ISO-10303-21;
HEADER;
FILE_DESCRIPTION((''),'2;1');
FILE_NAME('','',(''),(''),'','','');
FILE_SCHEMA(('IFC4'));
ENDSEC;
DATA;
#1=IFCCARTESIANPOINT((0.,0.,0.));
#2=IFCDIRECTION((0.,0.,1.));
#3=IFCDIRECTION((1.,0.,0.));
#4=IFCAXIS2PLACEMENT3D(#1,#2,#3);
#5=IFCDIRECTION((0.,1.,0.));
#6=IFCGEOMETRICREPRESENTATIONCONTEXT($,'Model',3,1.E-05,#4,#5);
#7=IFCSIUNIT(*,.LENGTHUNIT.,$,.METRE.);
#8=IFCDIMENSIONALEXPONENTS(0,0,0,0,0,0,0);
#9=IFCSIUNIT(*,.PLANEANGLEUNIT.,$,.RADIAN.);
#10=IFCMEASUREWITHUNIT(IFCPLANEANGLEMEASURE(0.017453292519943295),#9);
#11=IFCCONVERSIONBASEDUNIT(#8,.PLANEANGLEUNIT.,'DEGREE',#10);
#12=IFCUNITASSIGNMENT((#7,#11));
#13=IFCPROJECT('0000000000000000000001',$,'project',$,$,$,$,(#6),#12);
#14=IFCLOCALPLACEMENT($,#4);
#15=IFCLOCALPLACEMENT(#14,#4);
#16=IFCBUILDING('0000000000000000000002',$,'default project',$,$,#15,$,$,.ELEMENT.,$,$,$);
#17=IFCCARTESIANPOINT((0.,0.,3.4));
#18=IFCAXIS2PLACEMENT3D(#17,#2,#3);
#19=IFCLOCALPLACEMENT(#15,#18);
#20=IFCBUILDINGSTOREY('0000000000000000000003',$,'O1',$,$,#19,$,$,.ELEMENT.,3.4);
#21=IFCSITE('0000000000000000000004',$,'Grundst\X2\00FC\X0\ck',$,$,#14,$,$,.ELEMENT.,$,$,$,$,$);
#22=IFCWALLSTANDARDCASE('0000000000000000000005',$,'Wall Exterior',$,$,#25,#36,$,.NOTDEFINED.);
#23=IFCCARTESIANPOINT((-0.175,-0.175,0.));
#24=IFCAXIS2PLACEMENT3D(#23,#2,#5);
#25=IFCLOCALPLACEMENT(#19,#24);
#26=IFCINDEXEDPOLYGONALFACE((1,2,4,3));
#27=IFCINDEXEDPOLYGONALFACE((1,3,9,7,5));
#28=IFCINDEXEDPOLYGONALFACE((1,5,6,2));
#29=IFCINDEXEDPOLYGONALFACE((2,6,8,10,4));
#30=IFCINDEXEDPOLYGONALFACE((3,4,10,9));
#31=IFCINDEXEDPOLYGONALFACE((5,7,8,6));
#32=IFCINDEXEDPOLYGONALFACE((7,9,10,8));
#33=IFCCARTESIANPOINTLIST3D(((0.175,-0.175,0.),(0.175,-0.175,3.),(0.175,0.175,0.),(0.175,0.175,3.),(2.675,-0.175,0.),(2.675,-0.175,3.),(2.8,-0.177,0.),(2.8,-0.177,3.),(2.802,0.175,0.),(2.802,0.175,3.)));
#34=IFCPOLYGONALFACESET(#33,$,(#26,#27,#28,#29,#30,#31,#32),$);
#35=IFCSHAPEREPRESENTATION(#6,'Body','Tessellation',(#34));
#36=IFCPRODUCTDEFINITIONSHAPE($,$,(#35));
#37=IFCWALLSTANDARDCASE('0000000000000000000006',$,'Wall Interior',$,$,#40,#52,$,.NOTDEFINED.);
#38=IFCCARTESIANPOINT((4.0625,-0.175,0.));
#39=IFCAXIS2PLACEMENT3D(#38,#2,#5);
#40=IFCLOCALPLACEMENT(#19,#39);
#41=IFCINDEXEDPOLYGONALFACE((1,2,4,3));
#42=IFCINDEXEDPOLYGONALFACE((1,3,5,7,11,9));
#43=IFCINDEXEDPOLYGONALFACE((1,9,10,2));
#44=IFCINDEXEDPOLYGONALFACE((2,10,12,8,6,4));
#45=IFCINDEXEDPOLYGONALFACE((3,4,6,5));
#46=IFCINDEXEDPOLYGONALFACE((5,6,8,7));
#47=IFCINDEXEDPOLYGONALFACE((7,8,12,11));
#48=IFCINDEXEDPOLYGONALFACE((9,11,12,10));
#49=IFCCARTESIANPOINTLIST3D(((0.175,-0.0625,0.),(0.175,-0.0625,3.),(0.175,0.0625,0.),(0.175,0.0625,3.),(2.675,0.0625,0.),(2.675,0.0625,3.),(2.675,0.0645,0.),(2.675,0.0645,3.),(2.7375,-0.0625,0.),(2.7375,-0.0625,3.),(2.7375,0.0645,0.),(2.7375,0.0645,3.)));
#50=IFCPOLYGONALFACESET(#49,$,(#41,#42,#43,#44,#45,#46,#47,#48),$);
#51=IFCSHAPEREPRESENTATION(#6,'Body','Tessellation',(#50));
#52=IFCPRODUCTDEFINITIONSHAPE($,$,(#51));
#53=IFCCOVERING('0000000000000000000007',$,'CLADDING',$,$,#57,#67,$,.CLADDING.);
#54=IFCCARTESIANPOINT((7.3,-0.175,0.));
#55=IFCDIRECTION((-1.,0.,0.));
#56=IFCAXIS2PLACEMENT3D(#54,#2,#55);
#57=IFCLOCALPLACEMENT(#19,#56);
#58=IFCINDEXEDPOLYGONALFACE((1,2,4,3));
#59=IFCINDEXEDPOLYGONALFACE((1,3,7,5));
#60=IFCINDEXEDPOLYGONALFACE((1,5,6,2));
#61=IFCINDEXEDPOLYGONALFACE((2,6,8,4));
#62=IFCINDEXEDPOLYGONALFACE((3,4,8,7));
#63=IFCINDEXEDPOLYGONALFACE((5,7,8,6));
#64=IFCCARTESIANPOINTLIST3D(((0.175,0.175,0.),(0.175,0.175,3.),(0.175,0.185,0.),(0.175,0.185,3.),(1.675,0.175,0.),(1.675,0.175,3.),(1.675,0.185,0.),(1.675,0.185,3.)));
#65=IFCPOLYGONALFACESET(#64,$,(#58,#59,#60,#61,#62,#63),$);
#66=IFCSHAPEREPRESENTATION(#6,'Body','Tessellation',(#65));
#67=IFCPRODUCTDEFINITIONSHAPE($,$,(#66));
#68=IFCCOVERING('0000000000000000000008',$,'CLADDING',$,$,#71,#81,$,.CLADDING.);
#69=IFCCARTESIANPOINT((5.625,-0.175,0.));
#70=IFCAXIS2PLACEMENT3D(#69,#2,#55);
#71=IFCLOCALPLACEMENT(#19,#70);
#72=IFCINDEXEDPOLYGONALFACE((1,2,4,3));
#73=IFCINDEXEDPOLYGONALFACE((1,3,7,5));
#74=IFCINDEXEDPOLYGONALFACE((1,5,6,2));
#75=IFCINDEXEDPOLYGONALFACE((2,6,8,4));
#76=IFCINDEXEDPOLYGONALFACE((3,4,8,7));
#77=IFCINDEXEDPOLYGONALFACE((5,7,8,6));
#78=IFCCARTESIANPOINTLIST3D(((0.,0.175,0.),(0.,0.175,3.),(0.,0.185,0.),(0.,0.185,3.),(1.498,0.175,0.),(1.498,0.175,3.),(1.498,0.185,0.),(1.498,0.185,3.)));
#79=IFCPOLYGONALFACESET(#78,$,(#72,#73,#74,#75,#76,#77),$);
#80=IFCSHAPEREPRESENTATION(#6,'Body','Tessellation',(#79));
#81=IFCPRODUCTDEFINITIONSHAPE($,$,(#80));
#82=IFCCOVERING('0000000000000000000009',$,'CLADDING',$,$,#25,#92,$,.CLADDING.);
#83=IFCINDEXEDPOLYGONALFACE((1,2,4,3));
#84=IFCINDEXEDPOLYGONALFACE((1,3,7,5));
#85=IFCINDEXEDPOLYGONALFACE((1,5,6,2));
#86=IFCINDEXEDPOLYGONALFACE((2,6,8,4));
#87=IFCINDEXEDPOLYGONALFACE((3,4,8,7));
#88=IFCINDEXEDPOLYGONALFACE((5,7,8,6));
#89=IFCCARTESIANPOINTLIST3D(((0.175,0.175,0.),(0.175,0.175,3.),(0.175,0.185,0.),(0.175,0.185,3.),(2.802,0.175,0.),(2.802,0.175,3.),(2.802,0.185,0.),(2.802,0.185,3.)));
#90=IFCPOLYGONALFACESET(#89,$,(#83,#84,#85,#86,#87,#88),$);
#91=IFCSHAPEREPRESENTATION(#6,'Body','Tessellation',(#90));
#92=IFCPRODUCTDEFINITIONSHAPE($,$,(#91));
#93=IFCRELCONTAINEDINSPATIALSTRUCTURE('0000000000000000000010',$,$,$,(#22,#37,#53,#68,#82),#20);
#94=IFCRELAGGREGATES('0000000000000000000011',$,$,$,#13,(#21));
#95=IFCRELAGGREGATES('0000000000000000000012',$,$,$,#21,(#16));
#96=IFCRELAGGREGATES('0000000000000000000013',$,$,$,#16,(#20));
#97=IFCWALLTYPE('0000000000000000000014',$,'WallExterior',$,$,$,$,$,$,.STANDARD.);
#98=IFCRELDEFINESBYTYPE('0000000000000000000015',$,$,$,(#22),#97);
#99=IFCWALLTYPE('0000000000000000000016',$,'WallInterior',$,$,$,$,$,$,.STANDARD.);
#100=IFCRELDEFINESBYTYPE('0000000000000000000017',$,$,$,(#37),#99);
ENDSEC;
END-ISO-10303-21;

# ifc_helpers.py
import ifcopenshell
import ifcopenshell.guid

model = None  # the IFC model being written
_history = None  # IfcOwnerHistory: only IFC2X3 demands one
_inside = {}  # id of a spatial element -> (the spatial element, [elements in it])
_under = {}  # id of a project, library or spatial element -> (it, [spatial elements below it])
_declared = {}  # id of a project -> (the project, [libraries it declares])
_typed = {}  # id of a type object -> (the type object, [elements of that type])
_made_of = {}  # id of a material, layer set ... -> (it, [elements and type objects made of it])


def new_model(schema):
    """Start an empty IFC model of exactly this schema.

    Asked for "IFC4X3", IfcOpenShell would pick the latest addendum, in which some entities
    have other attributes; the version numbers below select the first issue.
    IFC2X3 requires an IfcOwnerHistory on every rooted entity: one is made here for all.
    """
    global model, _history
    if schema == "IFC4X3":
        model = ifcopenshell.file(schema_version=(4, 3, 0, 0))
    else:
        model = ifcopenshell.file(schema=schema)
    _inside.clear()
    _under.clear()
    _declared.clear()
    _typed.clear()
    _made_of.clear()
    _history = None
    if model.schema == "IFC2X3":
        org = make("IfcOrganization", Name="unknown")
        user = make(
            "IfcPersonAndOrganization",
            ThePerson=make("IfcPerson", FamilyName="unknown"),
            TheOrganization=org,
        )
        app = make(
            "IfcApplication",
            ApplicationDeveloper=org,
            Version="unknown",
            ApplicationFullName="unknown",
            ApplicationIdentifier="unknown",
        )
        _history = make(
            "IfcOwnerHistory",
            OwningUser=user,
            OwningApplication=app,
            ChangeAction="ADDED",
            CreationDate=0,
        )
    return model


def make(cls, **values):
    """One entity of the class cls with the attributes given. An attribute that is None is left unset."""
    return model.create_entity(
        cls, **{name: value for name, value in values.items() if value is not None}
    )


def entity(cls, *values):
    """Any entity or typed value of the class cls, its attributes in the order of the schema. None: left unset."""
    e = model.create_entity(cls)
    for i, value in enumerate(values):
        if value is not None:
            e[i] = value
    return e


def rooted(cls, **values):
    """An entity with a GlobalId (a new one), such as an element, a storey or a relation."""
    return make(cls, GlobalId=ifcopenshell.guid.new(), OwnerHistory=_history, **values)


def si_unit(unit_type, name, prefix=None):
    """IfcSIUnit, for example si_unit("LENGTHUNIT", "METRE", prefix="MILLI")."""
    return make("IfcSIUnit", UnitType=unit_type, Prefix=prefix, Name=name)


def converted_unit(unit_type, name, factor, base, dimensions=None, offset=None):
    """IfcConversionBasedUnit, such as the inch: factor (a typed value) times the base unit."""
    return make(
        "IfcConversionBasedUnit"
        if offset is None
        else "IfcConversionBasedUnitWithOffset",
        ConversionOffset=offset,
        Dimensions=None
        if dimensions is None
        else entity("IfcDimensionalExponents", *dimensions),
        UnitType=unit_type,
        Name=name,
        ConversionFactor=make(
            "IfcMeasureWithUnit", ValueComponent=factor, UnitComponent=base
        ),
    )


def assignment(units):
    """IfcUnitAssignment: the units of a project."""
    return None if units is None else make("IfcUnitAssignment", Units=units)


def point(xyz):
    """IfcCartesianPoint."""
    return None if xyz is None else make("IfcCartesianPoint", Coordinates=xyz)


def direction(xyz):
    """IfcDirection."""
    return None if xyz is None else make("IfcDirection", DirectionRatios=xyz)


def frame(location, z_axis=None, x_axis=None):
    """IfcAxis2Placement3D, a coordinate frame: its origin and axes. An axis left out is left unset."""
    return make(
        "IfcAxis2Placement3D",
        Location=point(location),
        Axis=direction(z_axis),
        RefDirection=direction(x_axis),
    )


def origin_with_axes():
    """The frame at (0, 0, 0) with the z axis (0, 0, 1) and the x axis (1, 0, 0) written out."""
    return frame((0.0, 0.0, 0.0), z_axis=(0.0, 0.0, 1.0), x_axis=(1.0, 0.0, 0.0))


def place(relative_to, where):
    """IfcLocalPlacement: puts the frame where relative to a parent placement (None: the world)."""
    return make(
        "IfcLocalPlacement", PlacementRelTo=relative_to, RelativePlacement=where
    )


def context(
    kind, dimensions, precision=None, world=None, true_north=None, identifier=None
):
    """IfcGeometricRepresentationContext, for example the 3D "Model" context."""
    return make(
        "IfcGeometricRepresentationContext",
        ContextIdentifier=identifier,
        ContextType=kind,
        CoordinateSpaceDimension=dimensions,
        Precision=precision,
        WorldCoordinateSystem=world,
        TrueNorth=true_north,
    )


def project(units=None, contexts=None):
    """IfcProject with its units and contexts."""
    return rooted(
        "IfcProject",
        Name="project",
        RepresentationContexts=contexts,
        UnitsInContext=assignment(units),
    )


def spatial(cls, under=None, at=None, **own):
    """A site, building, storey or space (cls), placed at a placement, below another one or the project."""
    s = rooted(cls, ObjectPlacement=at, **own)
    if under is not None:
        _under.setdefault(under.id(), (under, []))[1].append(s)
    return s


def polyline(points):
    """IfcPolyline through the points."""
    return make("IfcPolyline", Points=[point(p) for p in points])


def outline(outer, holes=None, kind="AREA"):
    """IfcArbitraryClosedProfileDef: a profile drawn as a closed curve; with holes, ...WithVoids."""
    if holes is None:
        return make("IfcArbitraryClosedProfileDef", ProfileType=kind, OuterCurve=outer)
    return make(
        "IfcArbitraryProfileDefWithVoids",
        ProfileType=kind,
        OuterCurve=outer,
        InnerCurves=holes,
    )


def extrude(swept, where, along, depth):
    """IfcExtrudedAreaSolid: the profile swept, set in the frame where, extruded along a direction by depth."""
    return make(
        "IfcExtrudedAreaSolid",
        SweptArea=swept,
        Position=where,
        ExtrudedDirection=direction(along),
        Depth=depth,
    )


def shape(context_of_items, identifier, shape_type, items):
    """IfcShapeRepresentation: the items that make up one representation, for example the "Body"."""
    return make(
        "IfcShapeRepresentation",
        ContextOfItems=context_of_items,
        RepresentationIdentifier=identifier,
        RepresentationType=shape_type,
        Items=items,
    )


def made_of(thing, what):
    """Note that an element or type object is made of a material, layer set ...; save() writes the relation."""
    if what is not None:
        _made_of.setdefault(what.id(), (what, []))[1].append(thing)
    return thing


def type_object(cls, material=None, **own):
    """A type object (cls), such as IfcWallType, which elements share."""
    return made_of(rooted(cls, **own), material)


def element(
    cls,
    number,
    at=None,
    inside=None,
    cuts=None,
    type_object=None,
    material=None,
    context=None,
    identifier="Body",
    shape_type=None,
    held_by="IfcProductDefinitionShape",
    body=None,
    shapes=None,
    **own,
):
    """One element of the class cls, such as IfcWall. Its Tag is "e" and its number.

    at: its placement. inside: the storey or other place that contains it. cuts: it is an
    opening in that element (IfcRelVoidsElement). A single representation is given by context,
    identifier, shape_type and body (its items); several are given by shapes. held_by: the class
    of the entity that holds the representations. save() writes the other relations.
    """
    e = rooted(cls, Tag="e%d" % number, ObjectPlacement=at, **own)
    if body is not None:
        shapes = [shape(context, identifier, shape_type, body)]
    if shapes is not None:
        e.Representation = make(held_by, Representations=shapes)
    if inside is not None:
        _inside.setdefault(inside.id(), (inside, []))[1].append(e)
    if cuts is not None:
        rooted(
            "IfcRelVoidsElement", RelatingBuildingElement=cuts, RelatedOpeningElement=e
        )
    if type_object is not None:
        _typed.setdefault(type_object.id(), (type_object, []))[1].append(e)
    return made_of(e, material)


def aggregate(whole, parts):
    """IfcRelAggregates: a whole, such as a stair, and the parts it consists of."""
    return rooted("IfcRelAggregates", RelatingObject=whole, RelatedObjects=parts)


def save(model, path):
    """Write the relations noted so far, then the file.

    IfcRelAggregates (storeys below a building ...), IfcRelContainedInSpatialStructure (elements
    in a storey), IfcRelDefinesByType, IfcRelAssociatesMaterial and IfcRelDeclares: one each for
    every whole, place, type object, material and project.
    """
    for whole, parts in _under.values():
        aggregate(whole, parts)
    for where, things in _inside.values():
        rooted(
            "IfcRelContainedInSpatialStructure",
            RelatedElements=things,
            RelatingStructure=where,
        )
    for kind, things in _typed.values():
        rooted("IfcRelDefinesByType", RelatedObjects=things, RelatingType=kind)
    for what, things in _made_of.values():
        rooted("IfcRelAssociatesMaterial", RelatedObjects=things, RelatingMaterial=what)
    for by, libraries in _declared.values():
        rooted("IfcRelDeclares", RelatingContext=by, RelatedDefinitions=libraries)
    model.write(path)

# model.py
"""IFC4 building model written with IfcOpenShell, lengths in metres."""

from ifc_helpers import new_model, entity, si_unit, converted_unit, direction, frame, origin_with_axes, place, context, project, spatial, polyline, outline, extrude, type_object, element, save


model = new_model("IFC4")

# Units and contexts
model_context = context("Model", 3, precision=1e-05, world=origin_with_axes(), true_north=direction((0.0, 1.0, 0.0)))
ifc_project = project(units=[si_unit("LENGTHUNIT", "METRE"), converted_unit("PLANEANGLEUNIT", "DEGREE", entity("IfcPlaneAngleMeasure", 0.017453292519943295), si_unit("PLANEANGLEUNIT", "RADIAN"), dimensions=[0, 0, 0, 0, 0, 0, 0])], contexts=[model_context])

# Site, building, storey
site_placement = place(None, origin_with_axes())
site = spatial("IfcSite", under=ifc_project, at=site_placement, Name="Grundstück", CompositionType="ELEMENT")
building_placement = place(site_placement, origin_with_axes())
building = spatial("IfcBuilding", under=site, at=building_placement, Name="default project", CompositionType="ELEMENT")
placement_1 = place(building_placement, frame((0.0, 0.0, 3.4), z_axis=(0.0, 0.0, 1.0), x_axis=(1.0, 0.0, 0.0)))
storey = spatial("IfcBuildingStorey", under=building, at=placement_1, Name="O1", CompositionType="ELEMENT", Elevation=3.4)

# Walls
wall_type_1 = type_object("IfcWallType", Name="WallExterior", PredefinedType="STANDARD")
placement_2 = place(placement_1, frame((7.3, -0.175, 0.0), z_axis=(0.0, 0.0, 1.0), x_axis=(-1.0, 0.0, 0.0)))
placement_3 = place(placement_1, frame((5.625, -0.175, 0.0), z_axis=(0.0, 0.0, 1.0), x_axis=(-1.0, 0.0, 0.0)))
placement_4 = place(placement_1, frame((-0.175, -0.175, 0.0), z_axis=(0.0, 0.0, 1.0), x_axis=(0.0, 1.0, 0.0)))
element("IfcWallStandardCase", 1, at=placement_4, inside=storey, type_object=wall_type_1, Name="Wall Exterior", PredefinedType="NOTDEFINED", context=model_context, shape_type="SweptSolid", body=[
    extrude(outline(polyline([(2.802, 0.175), (0.175, 0.175), (0.175, -0.175), (2.675, -0.175), (2.8, -0.177), (2.802, 0.175)])), origin_with_axes(), (0.0, 0.0, 1.0), 3.0),
])
wall_type_2 = type_object("IfcWallType", Name="WallInterior", PredefinedType="STANDARD")
wall_1_placement = place(placement_1, frame((4.0625, -0.175, 0.0), z_axis=(0.0, 0.0, 1.0), x_axis=(0.0, 1.0, 0.0)))
element("IfcWallStandardCase", 2, at=wall_1_placement, inside=storey, type_object=wall_type_2, Name="Wall Interior", PredefinedType="NOTDEFINED", context=model_context, shape_type="SweptSolid", body=[
    extrude(outline(polyline([(2.675, 0.0625), (0.175, 0.0625), (0.175, -0.0625), (2.7375, -0.0625), (2.7375, 0.0645), (2.675, 0.0645), (2.675, 0.0625)])), origin_with_axes(), (0.0, 0.0, 1.0), 3.0),
])

# Coverings
element("IfcCovering", 3, at=placement_2, inside=storey, Name="CLADDING", PredefinedType="CLADDING", context=model_context, shape_type="SweptSolid", body=[
    extrude(outline(polyline([(1.675, 0.185), (0.175, 0.185), (0.175, 0.175), (1.675, 0.175), (1.675, 0.185)])), origin_with_axes(), (0.0, 0.0, 1.0), 3.0),
])
element("IfcCovering", 4, at=placement_3, inside=storey, Name="CLADDING", PredefinedType="CLADDING", context=model_context, shape_type="SweptSolid", body=[
    extrude(outline(polyline([(1.498, 0.185), (0.0, 0.185), (0.0, 0.175), (1.498, 0.175), (1.498, 0.185)])), origin_with_axes(), (0.0, 0.0, 1.0), 3.0),
])
element("IfcCovering", 5, at=placement_4, inside=storey, Name="CLADDING", PredefinedType="CLADDING", context=model_context, shape_type="SweptSolid", body=[
    extrude(outline(polyline([(2.802, 0.185), (0.175, 0.185), (0.175, 0.175), (2.802, 0.175), (2.802, 0.185)])), origin_with_axes(), (0.0, 0.0, 1.0), 3.0),
])

save(model, "model.ifc")
